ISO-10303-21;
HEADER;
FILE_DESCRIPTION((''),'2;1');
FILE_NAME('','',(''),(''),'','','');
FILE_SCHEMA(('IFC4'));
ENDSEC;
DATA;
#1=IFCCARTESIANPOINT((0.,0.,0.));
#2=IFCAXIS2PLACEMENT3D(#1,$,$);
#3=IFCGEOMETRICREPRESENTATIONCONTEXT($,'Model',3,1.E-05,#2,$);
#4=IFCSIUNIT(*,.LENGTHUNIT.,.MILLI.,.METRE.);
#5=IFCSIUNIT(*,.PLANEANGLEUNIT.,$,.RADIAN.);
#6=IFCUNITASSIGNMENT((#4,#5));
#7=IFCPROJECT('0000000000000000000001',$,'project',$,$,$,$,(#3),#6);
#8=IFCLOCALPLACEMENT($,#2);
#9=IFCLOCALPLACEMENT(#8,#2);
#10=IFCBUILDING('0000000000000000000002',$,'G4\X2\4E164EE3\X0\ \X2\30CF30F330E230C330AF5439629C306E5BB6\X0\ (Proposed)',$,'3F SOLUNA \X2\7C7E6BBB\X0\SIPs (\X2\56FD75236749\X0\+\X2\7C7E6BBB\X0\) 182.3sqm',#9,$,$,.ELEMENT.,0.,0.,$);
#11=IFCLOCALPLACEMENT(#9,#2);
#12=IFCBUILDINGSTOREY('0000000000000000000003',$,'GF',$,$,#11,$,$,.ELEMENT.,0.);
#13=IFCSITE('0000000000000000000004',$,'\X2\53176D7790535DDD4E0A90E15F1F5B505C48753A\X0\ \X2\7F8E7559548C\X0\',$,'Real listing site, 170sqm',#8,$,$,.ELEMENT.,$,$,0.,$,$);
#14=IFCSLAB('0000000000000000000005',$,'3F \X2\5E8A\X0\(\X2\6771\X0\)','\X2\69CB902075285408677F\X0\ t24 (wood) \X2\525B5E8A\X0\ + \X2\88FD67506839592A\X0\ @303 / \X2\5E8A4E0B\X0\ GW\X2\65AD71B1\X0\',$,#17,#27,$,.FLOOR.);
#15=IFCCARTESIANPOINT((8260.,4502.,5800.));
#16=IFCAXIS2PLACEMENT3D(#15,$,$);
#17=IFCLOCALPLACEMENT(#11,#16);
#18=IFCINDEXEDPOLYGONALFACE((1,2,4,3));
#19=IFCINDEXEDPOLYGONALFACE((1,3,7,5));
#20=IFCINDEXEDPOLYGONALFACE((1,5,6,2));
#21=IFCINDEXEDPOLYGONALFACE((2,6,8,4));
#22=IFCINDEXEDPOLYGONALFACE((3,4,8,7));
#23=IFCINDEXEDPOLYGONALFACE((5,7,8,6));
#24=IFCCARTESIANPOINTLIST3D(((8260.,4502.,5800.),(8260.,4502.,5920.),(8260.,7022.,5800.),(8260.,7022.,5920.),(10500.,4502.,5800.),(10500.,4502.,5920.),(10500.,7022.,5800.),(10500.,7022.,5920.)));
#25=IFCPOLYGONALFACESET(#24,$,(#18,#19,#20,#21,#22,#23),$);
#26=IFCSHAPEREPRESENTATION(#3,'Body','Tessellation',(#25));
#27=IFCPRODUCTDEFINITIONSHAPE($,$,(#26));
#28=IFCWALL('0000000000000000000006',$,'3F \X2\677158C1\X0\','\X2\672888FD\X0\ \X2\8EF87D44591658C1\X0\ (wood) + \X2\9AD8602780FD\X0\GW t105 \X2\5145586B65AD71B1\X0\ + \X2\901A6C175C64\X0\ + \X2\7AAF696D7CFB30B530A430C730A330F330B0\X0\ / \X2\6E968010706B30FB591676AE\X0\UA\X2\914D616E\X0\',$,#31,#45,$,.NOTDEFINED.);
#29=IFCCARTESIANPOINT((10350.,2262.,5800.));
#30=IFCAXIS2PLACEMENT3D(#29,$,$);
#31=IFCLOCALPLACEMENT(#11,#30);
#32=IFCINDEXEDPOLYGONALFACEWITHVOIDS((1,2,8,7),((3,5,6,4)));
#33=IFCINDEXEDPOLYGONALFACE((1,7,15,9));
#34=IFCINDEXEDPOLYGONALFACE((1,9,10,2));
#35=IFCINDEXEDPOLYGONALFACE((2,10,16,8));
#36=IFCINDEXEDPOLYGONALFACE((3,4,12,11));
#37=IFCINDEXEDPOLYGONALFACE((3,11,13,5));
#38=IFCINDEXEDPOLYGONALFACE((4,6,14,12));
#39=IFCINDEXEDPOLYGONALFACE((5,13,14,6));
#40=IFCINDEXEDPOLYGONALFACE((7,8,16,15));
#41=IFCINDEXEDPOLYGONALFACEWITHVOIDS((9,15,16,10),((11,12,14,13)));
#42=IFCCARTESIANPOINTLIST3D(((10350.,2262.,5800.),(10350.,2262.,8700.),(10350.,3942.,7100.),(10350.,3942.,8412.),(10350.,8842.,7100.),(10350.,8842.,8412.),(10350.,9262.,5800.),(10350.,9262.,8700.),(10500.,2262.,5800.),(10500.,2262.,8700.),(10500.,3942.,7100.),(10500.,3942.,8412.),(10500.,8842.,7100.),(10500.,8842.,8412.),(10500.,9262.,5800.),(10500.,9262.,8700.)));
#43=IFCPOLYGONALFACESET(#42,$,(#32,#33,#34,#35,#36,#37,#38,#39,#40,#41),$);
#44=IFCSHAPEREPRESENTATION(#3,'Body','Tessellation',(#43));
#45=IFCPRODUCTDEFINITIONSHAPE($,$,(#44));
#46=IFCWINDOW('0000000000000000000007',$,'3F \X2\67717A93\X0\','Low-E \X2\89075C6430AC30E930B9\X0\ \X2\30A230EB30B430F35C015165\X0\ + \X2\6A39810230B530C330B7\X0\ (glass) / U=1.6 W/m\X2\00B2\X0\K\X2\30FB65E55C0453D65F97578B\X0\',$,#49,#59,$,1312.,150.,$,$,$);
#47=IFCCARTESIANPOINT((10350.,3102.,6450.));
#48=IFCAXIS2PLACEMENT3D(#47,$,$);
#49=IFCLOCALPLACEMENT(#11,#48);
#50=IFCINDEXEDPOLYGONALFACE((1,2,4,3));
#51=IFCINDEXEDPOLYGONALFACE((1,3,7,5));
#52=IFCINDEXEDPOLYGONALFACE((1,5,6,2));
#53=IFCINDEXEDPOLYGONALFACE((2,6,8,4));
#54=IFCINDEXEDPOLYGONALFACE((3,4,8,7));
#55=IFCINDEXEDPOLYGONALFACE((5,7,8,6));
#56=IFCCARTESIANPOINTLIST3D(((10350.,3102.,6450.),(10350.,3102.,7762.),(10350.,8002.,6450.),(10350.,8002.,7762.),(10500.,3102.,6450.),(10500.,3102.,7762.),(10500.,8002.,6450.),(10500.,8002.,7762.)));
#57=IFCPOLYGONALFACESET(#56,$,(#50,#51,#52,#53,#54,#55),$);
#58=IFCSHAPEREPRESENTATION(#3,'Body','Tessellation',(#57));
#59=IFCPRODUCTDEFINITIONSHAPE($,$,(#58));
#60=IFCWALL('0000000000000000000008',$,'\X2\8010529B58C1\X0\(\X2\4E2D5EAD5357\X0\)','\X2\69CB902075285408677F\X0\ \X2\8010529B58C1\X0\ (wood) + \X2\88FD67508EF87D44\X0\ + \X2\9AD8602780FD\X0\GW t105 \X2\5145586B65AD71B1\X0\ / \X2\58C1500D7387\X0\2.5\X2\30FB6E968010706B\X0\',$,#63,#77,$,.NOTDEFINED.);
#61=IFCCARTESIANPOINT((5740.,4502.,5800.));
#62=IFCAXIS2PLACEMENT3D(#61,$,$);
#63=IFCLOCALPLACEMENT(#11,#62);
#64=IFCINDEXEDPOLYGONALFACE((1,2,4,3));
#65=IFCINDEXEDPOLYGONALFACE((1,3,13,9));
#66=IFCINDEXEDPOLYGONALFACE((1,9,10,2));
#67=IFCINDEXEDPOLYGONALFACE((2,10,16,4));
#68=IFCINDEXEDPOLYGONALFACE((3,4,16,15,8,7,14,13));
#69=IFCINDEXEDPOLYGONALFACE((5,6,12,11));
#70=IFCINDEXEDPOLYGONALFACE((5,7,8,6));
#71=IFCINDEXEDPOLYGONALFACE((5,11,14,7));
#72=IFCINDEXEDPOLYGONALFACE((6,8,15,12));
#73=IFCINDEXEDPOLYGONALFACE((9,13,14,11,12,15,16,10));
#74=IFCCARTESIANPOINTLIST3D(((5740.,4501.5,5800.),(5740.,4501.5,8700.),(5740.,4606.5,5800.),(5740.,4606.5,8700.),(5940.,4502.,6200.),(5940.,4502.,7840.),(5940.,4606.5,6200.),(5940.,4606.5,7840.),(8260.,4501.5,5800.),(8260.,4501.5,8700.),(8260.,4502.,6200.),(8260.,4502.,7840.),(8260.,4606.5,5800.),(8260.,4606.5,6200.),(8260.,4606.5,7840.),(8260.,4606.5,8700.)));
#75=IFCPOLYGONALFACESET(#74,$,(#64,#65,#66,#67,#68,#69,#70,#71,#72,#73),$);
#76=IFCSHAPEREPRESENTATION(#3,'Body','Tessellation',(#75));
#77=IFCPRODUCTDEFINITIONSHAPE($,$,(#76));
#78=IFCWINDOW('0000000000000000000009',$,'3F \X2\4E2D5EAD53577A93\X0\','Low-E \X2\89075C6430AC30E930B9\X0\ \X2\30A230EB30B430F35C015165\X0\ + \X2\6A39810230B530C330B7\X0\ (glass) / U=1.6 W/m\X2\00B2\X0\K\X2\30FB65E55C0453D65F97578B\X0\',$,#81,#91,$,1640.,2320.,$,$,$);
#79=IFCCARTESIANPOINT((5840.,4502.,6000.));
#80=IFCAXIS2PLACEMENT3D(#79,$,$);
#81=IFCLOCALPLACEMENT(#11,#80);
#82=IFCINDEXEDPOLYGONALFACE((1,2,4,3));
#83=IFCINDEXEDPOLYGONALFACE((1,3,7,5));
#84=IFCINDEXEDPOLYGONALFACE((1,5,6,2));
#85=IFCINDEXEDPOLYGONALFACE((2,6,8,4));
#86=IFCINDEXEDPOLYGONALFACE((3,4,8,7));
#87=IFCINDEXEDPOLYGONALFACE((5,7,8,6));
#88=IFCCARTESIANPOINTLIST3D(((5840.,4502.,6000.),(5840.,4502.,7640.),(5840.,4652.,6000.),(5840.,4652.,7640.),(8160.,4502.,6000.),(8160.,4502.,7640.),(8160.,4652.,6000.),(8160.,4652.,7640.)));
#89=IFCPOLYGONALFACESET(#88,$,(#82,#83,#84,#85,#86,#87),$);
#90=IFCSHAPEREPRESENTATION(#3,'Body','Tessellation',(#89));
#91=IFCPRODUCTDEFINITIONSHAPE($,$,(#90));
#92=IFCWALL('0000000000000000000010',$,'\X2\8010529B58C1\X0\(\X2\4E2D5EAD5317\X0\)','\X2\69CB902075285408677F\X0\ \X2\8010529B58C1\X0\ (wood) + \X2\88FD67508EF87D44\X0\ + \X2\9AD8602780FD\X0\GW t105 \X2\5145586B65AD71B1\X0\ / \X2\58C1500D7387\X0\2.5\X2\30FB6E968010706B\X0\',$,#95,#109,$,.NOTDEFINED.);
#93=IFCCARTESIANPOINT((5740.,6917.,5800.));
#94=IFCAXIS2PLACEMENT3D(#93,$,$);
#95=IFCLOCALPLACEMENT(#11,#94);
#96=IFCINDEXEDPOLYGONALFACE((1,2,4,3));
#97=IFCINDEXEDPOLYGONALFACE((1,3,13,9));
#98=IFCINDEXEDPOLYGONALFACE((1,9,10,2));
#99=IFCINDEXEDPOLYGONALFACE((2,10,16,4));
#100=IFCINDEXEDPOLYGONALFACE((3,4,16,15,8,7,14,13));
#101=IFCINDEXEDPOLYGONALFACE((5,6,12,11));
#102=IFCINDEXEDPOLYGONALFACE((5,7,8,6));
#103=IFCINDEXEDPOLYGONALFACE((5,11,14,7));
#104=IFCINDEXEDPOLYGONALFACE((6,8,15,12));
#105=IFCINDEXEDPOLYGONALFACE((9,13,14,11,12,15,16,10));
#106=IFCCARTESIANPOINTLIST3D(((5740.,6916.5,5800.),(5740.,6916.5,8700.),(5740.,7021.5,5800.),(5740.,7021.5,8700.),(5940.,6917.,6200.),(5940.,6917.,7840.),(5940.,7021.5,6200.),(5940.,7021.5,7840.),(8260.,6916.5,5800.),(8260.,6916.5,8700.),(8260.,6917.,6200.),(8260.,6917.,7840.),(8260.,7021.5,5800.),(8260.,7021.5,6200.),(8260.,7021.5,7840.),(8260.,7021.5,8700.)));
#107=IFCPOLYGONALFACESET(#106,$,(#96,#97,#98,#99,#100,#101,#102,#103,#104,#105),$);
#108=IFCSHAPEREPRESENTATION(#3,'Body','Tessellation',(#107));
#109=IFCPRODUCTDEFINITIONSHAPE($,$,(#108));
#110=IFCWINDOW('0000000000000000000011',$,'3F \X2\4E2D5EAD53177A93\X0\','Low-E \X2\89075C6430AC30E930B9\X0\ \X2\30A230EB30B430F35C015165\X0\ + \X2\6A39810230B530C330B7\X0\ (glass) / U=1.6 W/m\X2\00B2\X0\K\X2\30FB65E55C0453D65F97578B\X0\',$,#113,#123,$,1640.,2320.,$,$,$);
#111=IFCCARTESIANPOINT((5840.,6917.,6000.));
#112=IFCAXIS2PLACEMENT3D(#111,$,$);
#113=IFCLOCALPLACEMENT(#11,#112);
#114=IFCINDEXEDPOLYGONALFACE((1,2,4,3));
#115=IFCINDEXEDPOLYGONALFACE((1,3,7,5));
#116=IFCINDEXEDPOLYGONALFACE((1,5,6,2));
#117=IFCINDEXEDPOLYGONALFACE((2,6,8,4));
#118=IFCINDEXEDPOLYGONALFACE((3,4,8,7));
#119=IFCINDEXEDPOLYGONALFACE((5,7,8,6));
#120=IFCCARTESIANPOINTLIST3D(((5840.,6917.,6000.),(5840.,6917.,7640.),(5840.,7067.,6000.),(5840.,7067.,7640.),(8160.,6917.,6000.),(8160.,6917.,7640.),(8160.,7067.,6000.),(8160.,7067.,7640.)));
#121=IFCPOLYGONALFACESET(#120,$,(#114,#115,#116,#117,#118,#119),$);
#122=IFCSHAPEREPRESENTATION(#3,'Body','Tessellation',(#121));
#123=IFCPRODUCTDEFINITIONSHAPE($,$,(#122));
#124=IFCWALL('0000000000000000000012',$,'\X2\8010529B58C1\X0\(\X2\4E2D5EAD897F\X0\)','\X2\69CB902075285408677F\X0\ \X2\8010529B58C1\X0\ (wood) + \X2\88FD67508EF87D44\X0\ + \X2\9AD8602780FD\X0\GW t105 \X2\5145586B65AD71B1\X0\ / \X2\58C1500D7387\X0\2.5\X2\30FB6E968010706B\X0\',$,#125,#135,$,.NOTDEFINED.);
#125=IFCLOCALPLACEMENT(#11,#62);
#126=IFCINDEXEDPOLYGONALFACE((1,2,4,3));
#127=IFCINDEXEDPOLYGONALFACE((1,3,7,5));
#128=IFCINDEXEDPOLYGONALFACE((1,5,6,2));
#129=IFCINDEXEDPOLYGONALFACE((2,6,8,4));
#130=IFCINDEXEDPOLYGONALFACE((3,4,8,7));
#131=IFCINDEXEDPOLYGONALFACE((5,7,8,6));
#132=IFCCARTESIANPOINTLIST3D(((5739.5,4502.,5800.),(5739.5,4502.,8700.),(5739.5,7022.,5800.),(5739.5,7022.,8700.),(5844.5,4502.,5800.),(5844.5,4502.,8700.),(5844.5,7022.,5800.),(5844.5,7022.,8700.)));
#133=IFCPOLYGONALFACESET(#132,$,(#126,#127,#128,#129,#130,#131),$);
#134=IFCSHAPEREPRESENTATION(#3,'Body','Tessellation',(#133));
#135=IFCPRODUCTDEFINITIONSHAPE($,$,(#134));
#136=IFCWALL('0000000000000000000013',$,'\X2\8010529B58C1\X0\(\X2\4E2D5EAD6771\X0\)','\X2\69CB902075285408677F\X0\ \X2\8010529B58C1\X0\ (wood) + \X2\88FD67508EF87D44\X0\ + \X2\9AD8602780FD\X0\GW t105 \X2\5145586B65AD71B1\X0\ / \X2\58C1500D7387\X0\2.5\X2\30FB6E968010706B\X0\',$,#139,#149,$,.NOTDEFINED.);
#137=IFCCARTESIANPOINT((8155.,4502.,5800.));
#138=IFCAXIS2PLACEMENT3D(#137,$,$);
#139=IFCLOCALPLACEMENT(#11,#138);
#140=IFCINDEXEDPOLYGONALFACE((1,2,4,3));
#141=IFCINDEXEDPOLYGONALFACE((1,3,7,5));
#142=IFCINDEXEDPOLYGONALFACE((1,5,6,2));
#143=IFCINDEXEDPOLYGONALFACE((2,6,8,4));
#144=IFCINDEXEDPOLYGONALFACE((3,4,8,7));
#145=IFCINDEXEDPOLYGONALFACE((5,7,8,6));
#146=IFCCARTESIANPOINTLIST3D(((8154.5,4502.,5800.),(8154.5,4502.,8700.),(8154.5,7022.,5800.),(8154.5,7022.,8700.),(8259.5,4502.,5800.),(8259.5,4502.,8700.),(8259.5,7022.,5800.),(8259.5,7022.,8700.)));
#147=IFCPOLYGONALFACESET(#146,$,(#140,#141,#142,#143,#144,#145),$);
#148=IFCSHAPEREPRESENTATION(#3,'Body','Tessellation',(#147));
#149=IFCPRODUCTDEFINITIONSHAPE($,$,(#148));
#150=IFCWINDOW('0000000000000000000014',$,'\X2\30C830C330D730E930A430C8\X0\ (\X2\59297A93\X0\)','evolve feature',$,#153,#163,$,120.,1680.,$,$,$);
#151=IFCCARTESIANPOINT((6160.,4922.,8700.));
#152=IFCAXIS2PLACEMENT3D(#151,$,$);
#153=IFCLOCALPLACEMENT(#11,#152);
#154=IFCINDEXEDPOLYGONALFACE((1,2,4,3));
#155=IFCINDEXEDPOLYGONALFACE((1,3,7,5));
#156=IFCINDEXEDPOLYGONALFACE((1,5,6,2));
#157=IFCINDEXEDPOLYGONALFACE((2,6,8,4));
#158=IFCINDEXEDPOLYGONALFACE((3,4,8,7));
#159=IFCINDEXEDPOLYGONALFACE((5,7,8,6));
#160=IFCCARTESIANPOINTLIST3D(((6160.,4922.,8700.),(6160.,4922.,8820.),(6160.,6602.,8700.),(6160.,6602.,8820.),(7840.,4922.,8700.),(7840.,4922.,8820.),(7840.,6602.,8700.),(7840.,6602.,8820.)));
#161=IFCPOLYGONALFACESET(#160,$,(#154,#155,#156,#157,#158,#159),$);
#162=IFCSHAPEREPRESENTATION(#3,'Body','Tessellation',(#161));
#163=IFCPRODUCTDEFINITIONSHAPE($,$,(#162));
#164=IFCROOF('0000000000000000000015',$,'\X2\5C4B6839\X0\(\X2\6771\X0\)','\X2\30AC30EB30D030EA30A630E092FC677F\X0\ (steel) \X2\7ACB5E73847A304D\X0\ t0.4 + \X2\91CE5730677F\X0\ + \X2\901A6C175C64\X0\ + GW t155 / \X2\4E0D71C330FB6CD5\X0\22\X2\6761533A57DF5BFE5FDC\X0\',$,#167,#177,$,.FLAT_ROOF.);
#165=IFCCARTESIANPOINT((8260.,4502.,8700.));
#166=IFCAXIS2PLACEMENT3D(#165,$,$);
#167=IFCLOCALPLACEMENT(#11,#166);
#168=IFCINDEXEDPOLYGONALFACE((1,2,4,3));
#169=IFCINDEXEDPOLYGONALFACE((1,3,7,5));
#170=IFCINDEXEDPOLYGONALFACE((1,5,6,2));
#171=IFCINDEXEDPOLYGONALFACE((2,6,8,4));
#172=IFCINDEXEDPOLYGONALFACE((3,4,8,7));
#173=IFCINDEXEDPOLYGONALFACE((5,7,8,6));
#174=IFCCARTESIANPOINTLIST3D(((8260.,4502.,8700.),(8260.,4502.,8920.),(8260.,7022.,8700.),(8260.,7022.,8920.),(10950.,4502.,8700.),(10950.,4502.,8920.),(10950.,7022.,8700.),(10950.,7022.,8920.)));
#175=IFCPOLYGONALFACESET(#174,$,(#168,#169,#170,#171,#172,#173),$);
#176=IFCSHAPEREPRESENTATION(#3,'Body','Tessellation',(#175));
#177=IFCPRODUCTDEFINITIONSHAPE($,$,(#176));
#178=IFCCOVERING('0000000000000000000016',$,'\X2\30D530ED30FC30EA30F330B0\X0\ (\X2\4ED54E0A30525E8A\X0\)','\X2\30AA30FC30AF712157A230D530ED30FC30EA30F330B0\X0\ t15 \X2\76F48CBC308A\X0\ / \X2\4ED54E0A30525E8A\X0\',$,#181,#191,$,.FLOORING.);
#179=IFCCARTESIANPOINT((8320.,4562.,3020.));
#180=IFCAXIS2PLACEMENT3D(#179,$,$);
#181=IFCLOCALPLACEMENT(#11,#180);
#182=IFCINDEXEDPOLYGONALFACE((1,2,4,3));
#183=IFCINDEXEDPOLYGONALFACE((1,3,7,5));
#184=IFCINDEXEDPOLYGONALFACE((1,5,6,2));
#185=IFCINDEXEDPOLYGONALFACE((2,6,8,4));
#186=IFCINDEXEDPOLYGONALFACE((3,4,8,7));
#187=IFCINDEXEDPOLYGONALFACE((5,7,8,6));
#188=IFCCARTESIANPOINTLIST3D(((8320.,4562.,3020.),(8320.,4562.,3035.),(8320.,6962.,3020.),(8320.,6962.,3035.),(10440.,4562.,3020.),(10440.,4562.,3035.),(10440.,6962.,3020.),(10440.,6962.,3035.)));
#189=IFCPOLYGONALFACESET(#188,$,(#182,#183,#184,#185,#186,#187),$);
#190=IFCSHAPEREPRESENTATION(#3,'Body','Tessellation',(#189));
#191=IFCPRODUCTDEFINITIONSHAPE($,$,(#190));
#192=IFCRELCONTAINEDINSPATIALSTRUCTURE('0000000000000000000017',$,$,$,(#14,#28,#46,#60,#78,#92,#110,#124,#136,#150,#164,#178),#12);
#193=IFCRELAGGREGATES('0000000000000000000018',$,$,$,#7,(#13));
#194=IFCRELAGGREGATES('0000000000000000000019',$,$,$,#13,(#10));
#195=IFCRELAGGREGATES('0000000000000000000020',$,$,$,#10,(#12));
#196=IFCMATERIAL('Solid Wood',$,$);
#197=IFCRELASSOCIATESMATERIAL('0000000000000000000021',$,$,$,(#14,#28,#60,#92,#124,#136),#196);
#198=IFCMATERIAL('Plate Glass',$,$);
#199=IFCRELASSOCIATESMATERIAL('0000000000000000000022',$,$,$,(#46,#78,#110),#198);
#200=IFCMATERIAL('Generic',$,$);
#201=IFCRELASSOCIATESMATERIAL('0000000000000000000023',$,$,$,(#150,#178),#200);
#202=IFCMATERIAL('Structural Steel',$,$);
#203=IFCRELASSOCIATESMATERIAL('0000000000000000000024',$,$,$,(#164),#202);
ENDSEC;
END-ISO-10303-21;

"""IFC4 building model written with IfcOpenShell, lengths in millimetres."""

from ifc_helpers import new_model, si_unit, frame, frame_2d, origin, place, context, project, spatial, rectangle, extrude, material, element, fill, save


model = new_model("IFC4")

# Units and contexts
model_context = context("Model", 3, precision=1e-05, world=origin())
ifc_project = project(units=[si_unit("LENGTHUNIT", "METRE", prefix="MILLI"), si_unit("PLANEANGLEUNIT", "RADIAN")], contexts=[model_context])

# Site, building, storey
site_placement = place(None, origin())
site = spatial("IfcSite", under=ifc_project, at=site_placement, Name="北海道川上郡弟子屈町 美留和", ObjectType="Real listing site, 170sqm", CompositionType="ELEMENT", RefElevation=0.0)
building_placement = place(site_placement, origin())
building = spatial("IfcBuilding", under=site, at=building_placement, Name="G4世代 ハンモック吹抜の家 (Proposed)", ObjectType="3F SOLUNA 籾殻SIPs (国産杉+籾殻) 182.3sqm", CompositionType="ELEMENT", ElevationOfRefHeight=0.0, ElevationOfTerrain=0.0)
storey_placement = place(building_placement, origin())
storey = spatial("IfcBuildingStorey", under=building, at=storey_placement, Name="GF", CompositionType="ELEMENT", Elevation=0.0)

# Slab
ifc_material_1 = material(Name="Solid Wood")
slab_placement = place(storey_placement, frame((8260.0, 4502.0, 5800.0)))
element("IfcSlab", 1, at=slab_placement, inside=storey, material=ifc_material_1, Name="3F 床(東)", Description="構造用合板 t24 (wood) 剛床 + 製材根太 @303 / 床下 GW断熱", PredefinedType="FLOOR", context=model_context, shape_type="SweptSolid", body=[
    extrude(rectangle(XDim=2240.0, YDim=2520.0, at=frame_2d((1120.0, 1260.0))), frame((8260.0, 4502.0, 5800.0)), (0.0, 0.0, 1.0), 120.0),
])

# Walls, openings, windows
wall_1_placement = place(storey_placement, frame((10350.0, 2262.0, 5800.0)))
wall_1 = element("IfcWall", 2, at=wall_1_placement, inside=storey, material=ifc_material_1, Name="3F 東壁", Description="木製 軸組外壁 (wood) + 高性能GW t105 充填断熱 + 通気層 + 窯業系サイディング / 準耐火・外皮UA配慮", PredefinedType="NOTDEFINED", context=model_context, shape_type="SweptSolid", body=[
    extrude(rectangle(XDim=150.0, YDim=7000.0, at=frame_2d((75.0, 3500.0))), frame((10350.0, 2262.0, 5800.0)), (0.0, 0.0, 1.0), 2900.0),
])
opening_1_placement = place(storey_placement, frame((10350.0, 3102.0, 6450.0)))
opening_1 = element("IfcOpeningElement", 3, at=opening_1_placement, cuts=wall_1, PredefinedType="NOTDEFINED", context=model_context, shape_type="SweptSolid", body=[
    extrude(rectangle(XDim=150.0, YDim=4900.0, at=frame_2d((75.0, 2450.0))), frame((10350.0, 3102.0, 6450.0)), (0.0, 0.0, 1.0), 1312.0),
])
ifc_material_2 = material(Name="Plate Glass")
window_1_placement = place(storey_placement, frame((10350.0, 3102.0, 6450.0)))
window_1 = element("IfcWindow", 4, at=window_1_placement, inside=storey, material=ifc_material_2, Name="3F 東窓", Description="Low-E 複層ガラス アルゴン封入 + 樹脂サッシ (glass) / U=1.6 W/m²K・日射取得型", OverallHeight=1312.0, OverallWidth=150.0, context=model_context, shape_type="SweptSolid", body=[
    extrude(rectangle(XDim=150.0, YDim=4900.0, at=frame_2d((75.0, 2450.0))), frame((10350.0, 3102.0, 6450.0)), (0.0, 0.0, 1.0), 1312.0),
])
fill(opening_1, window_1)
wall_2_placement = place(storey_placement, frame((5740.0, 4502.0, 5800.0)))
wall_2 = element("IfcWall", 5, at=wall_2_placement, inside=storey, material=ifc_material_1, Name="耐力壁(中庭南)", Description="構造用合板 耐力壁 (wood) + 製材軸組 + 高性能GW t105 充填断熱 / 壁倍率2.5・準耐火", PredefinedType="NOTDEFINED", context=model_context, shape_type="SweptSolid", body=[
    extrude(rectangle(XDim=2520.0, YDim=105.0, at=frame_2d((1260.0, 52.0))), frame((5740.0, 4502.0, 5800.0)), (0.0, 0.0, 1.0), 2900.0),
])
opening_2_placement = place(storey_placement, frame((5840.0, 4502.0, 6000.0)))
opening_2 = element("IfcOpeningElement", 6, at=opening_2_placement, cuts=wall_2, PredefinedType="NOTDEFINED", context=model_context, shape_type="SweptSolid", body=[
    extrude(rectangle(XDim=2320.0, YDim=150.0, at=frame_2d((1160.0, 75.0))), frame((5840.0, 4502.0, 6000.0)), (0.0, 0.0, 1.0), 1640.0),
])
window_2_placement = place(storey_placement, frame((5840.0, 4502.0, 6000.0)))
window_2 = element("IfcWindow", 7, at=window_2_placement, inside=storey, material=ifc_material_2, Name="3F 中庭南窓", Description="Low-E 複層ガラス アルゴン封入 + 樹脂サッシ (glass) / U=1.6 W/m²K・日射取得型", OverallHeight=1640.0, OverallWidth=2320.0, context=model_context, shape_type="SweptSolid", body=[
    extrude(rectangle(XDim=2320.0, YDim=150.0, at=frame_2d((1160.0, 75.0))), frame((5840.0, 4502.0, 6000.0)), (0.0, 0.0, 1.0), 1640.0),
])
fill(opening_2, window_2)
wall_3_placement = place(storey_placement, frame((5740.0, 6917.0, 5800.0)))
wall_3 = element("IfcWall", 8, at=wall_3_placement, inside=storey, material=ifc_material_1, Name="耐力壁(中庭北)", Description="構造用合板 耐力壁 (wood) + 製材軸組 + 高性能GW t105 充填断熱 / 壁倍率2.5・準耐火", PredefinedType="NOTDEFINED", context=model_context, shape_type="SweptSolid", body=[
    extrude(rectangle(XDim=2520.0, YDim=105.0, at=frame_2d((1260.0, 52.0))), frame((5740.0, 6917.0, 5800.0)), (0.0, 0.0, 1.0), 2900.0),
])
opening_3_placement = place(storey_placement, frame((5840.0, 6917.0, 6000.0)))
opening_3 = element("IfcOpeningElement", 9, at=opening_3_placement, cuts=wall_3, PredefinedType="NOTDEFINED", context=model_context, shape_type="SweptSolid", body=[
    extrude(rectangle(XDim=2320.0, YDim=150.0, at=frame_2d((1160.0, 75.0))), frame((5840.0, 6917.0, 6000.0)), (0.0, 0.0, 1.0), 1640.0),
])
window_3_placement = place(storey_placement, frame((5840.0, 6917.0, 6000.0)))
window_3 = element("IfcWindow", 10, at=window_3_placement, inside=storey, material=ifc_material_2, Name="3F 中庭北窓", Description="Low-E 複層ガラス アルゴン封入 + 樹脂サッシ (glass) / U=1.6 W/m²K・日射取得型", OverallHeight=1640.0, OverallWidth=2320.0, context=model_context, shape_type="SweptSolid", body=[
    extrude(rectangle(XDim=2320.0, YDim=150.0, at=frame_2d((1160.0, 75.0))), frame((5840.0, 6917.0, 6000.0)), (0.0, 0.0, 1.0), 1640.0),
])
fill(opening_3, window_3)

# Walls
wall_4_placement = place(storey_placement, frame((5740.0, 4502.0, 5800.0)))
element("IfcWall", 11, at=wall_4_placement, inside=storey, material=ifc_material_1, Name="耐力壁(中庭西)", Description="構造用合板 耐力壁 (wood) + 製材軸組 + 高性能GW t105 充填断熱 / 壁倍率2.5・準耐火", PredefinedType="NOTDEFINED", context=model_context, shape_type="SweptSolid", body=[
    extrude(rectangle(XDim=105.0, YDim=2520.0, at=frame_2d((52.0, 1260.0))), frame((5740.0, 4502.0, 5800.0)), (0.0, 0.0, 1.0), 2900.0),
])
wall_5_placement = place(storey_placement, frame((8155.0, 4502.0, 5800.0)))
element("IfcWall", 12, at=wall_5_placement, inside=storey, material=ifc_material_1, Name="耐力壁(中庭東)", Description="構造用合板 耐力壁 (wood) + 製材軸組 + 高性能GW t105 充填断熱 / 壁倍率2.5・準耐火", PredefinedType="NOTDEFINED", context=model_context, shape_type="SweptSolid", body=[
    extrude(rectangle(XDim=105.0, YDim=2520.0, at=frame_2d((52.0, 1260.0))), frame((8155.0, 4502.0, 5800.0)), (0.0, 0.0, 1.0), 2900.0),
])

# Window
ifc_material_3 = material(Name="Generic")
window_4_placement = place(storey_placement, frame((6160.0, 4922.0, 8700.0)))
element("IfcWindow", 13, at=window_4_placement, inside=storey, material=ifc_material_3, Name="トップライト (天窓)", Description="evolve feature", OverallHeight=120.0, OverallWidth=1680.0, context=model_context, shape_type="SweptSolid", body=[
    extrude(rectangle(XDim=1680.0, YDim=1680.0, at=frame_2d((840.0, 840.0))), frame((6160.0, 4922.0, 8700.0)), (0.0, 0.0, 1.0), 120.0),
])

# Roof
ifc_material_4 = material(Name="Structural Steel")
for number, where, name in (
    (14, (8260.0, 4502.0, 8700.0), "屋根(東)"),
):
    element("IfcRoof", number, at=place(storey_placement, frame(where)), inside=storey, material=ifc_material_4, Name=name, Description="ガルバリウム鋼板 (steel) 立平葺き t0.4 + 野地板 + 通気層 + GW t155 / 不燃・法22条区域対応", PredefinedType="FLAT_ROOF", context=model_context, shape_type="SweptSolid", body=[
        extrude(rectangle(XDim=2690.0, YDim=2520.0, at=frame_2d((1345.0, 1260.0))), frame((8260.0, 4502.0, 8700.0)), (0.0, 0.0, 1.0), 220.0),
    ])

# Covering
covering_1_placement = place(storey_placement, frame((8320.0, 4562.0, 3020.0)))
element("IfcCovering", 15, at=covering_1_placement, inside=storey, material=ifc_material_3, Name="フローリング (仕上げ床)", Description="オーク無垢フローリング t15 直貼り / 仕上げ床", PredefinedType="FLOORING", context=model_context, shape_type="SweptSolid", body=[
    extrude(rectangle(XDim=2120.0, YDim=2400.0, at=frame_2d((1060.0, 1200.0))), frame((8320.0, 4562.0, 3020.0)), (0.0, 0.0, 1.0), 15.0),
])

save(model, "model.ifc")
